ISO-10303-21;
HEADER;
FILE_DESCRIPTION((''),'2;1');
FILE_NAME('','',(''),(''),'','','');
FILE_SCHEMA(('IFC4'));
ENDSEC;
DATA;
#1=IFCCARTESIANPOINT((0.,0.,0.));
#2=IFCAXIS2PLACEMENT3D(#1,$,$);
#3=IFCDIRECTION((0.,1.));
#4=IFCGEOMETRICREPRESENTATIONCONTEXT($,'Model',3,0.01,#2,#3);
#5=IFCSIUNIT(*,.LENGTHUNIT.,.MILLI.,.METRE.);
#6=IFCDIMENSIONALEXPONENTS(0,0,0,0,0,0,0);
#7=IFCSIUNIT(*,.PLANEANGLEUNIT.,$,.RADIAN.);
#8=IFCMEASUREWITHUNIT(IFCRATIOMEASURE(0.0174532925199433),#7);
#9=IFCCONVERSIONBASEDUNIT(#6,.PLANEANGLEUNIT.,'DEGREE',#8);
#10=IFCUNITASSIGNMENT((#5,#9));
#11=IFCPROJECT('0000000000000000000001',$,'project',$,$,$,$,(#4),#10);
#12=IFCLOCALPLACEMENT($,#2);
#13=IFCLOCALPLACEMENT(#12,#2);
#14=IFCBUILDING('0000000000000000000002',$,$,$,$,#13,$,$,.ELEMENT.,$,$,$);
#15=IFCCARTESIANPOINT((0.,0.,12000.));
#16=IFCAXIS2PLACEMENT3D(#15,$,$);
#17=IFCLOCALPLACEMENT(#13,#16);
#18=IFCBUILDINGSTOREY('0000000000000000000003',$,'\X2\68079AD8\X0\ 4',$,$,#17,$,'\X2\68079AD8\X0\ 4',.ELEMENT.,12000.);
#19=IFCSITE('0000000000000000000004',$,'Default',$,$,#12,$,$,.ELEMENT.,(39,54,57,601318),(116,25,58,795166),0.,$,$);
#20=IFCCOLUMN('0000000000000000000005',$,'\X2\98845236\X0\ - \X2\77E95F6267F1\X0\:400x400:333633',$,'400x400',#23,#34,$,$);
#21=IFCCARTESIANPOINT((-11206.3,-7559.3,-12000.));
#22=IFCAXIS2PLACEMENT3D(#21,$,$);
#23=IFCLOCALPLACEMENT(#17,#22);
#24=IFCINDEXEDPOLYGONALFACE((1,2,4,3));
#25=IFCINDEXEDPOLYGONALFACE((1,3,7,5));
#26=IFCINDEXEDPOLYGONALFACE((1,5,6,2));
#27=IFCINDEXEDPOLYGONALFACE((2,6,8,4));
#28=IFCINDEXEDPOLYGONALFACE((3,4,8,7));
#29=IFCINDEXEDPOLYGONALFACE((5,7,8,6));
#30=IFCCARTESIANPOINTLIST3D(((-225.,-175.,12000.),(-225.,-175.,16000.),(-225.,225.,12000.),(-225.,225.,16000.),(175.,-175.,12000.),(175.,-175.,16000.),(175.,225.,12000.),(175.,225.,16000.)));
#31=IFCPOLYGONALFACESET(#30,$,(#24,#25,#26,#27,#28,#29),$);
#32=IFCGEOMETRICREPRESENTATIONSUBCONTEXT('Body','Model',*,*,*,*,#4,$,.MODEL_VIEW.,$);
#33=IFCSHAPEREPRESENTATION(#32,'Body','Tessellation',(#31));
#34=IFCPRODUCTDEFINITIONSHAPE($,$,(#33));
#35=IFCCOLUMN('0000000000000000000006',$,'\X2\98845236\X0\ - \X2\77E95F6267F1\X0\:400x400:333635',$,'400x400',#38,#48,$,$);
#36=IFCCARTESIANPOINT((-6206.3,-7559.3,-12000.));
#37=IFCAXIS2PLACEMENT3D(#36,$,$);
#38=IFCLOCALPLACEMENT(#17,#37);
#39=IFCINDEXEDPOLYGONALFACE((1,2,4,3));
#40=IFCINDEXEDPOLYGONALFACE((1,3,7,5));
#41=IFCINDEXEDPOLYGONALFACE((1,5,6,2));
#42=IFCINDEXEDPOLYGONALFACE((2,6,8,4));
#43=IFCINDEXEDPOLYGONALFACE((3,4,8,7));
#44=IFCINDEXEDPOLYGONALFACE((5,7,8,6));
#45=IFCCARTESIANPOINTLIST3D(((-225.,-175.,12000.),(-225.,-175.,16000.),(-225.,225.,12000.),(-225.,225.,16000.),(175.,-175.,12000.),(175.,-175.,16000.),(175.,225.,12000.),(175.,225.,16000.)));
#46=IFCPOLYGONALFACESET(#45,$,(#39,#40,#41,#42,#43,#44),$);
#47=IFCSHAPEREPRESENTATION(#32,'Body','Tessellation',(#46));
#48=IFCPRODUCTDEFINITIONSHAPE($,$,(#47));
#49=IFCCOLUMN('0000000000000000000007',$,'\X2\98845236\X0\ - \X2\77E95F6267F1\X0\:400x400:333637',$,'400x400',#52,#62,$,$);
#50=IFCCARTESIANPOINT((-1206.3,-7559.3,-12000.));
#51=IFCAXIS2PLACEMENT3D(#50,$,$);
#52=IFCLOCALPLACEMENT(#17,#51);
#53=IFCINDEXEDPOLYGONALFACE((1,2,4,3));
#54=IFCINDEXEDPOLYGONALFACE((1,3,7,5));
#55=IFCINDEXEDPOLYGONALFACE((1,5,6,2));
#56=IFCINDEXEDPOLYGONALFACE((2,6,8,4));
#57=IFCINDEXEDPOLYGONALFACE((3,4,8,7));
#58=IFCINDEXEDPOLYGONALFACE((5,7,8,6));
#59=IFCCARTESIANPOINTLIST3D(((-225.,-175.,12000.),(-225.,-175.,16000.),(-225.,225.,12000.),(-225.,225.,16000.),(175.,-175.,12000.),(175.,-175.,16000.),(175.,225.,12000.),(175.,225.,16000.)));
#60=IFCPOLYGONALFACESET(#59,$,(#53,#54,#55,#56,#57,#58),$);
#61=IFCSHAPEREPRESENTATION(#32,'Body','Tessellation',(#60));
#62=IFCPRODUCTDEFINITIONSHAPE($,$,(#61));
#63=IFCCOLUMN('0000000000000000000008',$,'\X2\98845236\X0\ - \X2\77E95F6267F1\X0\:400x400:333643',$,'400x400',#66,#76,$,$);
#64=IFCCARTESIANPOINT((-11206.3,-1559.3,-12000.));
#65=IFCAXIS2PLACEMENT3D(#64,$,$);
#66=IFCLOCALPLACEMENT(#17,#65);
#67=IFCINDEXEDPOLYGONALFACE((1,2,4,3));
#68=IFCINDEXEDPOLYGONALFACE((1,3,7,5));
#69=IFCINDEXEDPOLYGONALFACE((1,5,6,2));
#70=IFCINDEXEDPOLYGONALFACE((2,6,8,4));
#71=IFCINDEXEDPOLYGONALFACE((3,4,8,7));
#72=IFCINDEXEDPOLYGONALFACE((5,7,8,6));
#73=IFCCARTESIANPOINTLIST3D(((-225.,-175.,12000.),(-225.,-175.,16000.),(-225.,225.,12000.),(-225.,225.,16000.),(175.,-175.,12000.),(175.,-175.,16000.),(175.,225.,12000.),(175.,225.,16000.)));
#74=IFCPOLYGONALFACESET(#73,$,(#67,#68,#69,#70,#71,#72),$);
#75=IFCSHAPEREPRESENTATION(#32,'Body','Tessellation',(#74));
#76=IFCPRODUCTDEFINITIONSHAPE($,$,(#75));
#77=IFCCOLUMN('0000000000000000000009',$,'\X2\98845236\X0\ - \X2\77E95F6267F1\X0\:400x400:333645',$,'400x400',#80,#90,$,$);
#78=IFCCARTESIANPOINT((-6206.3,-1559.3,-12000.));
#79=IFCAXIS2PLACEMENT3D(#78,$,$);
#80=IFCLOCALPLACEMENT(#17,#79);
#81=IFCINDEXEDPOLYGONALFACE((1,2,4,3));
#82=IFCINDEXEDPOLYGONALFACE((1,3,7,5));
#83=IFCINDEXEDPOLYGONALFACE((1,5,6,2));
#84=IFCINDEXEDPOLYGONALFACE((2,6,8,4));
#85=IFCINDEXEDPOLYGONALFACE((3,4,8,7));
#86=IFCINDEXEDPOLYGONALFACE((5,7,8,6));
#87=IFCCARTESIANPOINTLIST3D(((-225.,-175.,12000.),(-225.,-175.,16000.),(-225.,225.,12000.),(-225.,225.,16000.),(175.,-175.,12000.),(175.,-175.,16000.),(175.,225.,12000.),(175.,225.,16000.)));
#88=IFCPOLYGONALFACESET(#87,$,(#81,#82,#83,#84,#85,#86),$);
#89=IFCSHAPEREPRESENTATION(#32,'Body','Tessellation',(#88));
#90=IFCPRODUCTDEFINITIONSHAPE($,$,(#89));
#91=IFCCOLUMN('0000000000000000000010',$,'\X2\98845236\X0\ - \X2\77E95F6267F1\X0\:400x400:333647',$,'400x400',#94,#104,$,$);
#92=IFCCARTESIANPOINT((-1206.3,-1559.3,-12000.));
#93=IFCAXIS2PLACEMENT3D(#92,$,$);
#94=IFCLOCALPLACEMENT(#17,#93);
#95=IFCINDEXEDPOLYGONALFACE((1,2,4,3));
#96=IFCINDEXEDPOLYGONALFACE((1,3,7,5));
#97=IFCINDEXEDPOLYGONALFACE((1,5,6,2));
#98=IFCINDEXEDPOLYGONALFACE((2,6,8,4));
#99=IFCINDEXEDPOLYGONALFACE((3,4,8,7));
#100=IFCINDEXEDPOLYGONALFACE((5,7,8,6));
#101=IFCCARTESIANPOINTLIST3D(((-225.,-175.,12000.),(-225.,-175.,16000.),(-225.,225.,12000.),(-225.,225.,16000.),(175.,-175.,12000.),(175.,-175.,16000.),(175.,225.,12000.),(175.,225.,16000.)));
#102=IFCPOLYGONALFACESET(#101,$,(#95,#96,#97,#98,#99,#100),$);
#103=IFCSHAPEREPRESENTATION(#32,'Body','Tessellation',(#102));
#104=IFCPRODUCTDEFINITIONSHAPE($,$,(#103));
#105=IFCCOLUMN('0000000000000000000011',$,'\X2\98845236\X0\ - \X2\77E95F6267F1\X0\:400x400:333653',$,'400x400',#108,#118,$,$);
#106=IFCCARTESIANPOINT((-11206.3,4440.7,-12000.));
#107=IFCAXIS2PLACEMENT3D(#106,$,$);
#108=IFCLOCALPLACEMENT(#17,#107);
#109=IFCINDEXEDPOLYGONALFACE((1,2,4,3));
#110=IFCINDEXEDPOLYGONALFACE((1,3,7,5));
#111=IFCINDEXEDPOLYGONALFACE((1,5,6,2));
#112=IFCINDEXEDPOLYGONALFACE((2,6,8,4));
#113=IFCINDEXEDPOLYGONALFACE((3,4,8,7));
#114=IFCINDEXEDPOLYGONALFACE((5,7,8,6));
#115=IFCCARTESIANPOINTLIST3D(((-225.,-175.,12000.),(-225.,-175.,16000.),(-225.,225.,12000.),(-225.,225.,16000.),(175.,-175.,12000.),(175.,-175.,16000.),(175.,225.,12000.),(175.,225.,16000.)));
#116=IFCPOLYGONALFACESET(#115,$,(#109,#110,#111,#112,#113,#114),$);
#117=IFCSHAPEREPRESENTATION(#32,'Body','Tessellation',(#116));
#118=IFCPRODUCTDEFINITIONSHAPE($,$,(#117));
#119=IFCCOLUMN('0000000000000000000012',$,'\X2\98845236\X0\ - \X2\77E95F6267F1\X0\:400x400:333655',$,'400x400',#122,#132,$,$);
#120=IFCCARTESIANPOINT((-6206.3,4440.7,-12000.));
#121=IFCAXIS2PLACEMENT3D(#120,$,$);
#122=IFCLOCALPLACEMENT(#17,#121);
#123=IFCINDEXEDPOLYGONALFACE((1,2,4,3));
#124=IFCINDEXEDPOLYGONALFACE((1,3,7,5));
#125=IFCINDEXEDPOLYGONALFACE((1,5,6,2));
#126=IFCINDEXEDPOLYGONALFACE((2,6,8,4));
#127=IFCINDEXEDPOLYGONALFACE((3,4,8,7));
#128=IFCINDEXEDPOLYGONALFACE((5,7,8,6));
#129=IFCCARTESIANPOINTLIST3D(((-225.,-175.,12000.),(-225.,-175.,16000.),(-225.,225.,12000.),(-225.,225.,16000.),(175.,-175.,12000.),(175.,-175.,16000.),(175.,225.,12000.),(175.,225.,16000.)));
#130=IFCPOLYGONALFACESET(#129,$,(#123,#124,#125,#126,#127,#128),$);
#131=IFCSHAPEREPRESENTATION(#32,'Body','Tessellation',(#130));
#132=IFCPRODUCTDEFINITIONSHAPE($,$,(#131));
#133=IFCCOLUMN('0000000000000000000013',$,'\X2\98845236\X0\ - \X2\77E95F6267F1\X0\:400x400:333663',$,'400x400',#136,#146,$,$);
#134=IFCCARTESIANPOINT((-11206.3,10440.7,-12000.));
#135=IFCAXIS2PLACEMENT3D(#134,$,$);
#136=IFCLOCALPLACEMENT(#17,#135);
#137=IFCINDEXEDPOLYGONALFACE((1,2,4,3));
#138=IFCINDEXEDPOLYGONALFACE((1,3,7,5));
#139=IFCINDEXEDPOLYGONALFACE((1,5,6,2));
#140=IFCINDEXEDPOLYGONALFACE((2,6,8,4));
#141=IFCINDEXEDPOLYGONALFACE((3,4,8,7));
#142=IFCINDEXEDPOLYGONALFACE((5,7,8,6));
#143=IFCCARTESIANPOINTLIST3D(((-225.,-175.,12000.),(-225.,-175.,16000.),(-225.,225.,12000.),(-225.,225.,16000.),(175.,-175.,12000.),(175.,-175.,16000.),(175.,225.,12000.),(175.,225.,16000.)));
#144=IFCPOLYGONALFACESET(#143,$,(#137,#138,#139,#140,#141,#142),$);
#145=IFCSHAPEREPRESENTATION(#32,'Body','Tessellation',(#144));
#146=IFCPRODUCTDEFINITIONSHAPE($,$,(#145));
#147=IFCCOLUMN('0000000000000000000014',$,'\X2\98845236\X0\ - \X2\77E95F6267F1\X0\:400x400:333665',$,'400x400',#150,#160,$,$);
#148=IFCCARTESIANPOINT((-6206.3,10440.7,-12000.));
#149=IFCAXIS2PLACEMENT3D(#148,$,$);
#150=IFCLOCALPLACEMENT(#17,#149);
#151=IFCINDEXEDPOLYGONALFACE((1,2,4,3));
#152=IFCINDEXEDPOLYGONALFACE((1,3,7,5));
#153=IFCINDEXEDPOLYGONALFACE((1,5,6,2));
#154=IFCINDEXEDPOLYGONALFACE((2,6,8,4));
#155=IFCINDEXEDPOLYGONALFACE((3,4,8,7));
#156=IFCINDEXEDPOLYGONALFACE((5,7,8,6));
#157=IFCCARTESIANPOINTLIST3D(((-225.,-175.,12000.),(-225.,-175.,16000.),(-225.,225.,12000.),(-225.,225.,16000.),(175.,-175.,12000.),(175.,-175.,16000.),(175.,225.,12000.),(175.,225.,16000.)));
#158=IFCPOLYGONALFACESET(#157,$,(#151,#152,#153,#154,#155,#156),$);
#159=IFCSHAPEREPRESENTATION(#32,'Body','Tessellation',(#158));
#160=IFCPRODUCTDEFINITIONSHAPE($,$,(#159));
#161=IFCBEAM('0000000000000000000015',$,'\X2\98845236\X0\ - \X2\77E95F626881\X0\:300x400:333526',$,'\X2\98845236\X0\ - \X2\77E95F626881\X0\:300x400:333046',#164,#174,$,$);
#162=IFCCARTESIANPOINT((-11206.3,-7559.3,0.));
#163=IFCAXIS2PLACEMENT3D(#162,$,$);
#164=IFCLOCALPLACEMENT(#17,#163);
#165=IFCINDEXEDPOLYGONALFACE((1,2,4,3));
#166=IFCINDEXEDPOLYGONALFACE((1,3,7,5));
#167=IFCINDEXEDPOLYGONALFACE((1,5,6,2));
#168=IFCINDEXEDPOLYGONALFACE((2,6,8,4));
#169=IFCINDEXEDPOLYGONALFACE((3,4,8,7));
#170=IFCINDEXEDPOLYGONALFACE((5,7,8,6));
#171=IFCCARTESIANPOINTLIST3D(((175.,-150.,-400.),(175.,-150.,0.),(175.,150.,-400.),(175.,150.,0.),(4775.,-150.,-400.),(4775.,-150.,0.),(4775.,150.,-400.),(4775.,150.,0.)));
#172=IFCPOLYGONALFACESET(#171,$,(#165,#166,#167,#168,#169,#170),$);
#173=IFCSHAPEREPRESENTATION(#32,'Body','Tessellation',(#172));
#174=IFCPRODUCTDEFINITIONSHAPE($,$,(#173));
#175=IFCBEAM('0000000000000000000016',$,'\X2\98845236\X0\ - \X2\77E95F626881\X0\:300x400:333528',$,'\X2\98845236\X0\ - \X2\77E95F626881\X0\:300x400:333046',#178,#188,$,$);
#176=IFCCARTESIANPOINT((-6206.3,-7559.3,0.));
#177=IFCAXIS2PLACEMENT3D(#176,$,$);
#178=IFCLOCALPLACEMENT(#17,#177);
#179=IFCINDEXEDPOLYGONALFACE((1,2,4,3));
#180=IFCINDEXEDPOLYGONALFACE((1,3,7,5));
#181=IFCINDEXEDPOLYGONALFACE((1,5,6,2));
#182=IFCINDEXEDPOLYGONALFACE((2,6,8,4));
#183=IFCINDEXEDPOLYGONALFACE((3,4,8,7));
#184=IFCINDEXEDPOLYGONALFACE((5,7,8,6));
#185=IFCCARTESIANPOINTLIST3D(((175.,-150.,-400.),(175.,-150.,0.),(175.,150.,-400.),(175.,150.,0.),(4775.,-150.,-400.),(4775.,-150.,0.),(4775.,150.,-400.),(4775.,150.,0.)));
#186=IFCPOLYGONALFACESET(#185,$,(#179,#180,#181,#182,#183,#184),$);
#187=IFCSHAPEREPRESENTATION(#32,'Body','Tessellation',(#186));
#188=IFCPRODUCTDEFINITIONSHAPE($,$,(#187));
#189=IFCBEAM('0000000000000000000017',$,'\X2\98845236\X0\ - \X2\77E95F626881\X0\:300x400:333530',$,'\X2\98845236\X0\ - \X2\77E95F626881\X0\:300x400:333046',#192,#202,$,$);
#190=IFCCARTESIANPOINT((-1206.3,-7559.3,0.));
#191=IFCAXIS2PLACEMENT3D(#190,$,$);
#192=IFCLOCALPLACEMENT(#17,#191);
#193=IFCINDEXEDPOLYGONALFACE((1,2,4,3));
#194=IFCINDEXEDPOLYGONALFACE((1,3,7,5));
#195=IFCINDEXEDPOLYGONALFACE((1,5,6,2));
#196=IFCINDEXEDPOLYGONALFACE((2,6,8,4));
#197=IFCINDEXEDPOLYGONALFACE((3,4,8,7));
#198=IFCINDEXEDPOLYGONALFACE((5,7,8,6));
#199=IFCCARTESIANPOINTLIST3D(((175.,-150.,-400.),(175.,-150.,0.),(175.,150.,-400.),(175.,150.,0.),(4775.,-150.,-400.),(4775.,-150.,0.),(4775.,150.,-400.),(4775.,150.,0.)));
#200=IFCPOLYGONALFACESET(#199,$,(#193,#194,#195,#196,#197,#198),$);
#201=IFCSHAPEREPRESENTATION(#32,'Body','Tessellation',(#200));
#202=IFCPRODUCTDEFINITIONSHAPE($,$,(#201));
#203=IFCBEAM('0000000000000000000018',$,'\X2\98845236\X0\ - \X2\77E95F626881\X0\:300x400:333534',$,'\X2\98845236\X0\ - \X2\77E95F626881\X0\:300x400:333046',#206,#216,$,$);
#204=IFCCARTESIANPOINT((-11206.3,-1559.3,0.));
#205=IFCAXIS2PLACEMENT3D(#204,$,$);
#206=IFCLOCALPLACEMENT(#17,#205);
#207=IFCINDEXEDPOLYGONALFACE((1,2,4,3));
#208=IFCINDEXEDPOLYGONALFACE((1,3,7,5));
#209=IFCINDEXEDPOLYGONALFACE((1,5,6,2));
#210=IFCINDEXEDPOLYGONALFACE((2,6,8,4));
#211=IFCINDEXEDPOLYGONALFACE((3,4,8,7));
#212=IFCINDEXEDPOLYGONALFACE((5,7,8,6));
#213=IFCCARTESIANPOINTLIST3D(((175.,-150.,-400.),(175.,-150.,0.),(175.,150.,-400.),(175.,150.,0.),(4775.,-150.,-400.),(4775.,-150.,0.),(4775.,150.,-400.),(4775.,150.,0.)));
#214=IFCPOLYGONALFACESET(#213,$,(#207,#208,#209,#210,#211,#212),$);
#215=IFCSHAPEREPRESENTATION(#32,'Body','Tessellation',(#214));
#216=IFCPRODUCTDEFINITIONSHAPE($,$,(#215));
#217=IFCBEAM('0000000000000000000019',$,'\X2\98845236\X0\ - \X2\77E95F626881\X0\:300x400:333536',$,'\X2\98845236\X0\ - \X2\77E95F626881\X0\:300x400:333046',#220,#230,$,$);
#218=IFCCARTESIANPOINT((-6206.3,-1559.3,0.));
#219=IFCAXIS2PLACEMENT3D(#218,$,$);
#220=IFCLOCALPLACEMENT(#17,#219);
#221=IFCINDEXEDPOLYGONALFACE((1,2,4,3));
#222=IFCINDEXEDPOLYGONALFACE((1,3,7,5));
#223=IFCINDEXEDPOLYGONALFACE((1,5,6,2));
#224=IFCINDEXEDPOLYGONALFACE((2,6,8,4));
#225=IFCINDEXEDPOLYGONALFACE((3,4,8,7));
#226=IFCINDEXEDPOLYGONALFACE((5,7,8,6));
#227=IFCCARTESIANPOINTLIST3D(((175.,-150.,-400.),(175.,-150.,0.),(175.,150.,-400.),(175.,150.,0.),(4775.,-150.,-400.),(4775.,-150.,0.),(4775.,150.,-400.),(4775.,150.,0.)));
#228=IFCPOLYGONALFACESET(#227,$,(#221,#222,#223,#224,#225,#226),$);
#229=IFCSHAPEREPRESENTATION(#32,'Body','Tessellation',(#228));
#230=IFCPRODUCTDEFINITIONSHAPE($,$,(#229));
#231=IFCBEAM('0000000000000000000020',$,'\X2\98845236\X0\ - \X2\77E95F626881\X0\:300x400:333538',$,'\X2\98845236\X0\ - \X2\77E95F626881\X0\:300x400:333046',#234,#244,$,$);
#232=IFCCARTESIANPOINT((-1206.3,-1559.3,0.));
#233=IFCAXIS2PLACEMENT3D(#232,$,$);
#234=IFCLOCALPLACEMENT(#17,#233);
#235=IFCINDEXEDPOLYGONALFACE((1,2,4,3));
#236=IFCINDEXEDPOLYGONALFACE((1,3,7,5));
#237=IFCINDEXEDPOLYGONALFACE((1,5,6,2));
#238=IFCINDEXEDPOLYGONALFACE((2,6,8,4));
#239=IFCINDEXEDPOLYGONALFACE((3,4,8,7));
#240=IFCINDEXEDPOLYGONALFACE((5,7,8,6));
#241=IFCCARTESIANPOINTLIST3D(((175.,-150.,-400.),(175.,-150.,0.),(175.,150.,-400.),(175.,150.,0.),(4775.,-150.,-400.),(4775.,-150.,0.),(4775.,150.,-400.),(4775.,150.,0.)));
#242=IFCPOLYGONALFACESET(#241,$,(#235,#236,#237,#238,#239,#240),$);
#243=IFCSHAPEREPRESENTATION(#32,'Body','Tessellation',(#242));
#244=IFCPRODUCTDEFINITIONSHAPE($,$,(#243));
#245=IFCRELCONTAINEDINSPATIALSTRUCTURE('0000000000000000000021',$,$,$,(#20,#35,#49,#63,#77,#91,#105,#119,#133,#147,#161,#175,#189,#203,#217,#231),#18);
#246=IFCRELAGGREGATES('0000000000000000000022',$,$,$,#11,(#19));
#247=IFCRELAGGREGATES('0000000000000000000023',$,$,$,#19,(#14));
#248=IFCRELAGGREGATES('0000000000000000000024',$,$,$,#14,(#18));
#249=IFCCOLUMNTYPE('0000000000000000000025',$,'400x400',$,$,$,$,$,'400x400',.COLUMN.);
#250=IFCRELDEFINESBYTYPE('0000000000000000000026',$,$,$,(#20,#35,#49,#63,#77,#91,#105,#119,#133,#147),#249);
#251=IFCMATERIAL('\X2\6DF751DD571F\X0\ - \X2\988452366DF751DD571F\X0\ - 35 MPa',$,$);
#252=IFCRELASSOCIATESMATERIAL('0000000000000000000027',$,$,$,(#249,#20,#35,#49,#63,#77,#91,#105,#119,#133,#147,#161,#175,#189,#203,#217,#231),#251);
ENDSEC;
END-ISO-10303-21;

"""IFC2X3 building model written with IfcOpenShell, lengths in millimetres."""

from ifc_helpers import new_model, entity, si_unit, converted_unit, direction, frame, frame_2d, origin, place, context, subcontext, project, spatial, rectangle, extrude, source, transform, mapped, material, type_object, type_shapes, element, save


model = new_model("IFC2X3")

# Units and contexts
model_context = context("Model", 3, precision=0.01, world=origin(), true_north=direction((0.0, 1.0)))
body_context = subcontext(model_context, "Body", "Model", "MODEL_VIEW")
ifc_project = project(units=[si_unit("LENGTHUNIT", "METRE", prefix="MILLI"), converted_unit("PLANEANGLEUNIT", "DEGREE", entity("IfcRatioMeasure", 0.0174532925199433), si_unit("PLANEANGLEUNIT", "RADIAN"), dimensions=[0, 0, 0, 0, 0, 0, 0])], contexts=[model_context])

# Site, building, storey
site_placement = place(None, origin())
site = spatial("IfcSite", under=ifc_project, at=site_placement, Name="Default", CompositionType="ELEMENT", RefLatitude=(39, 54, 57, 601318), RefLongitude=(116, 25, 58, 795166), RefElevation=0.0)
building_placement = place(site_placement, origin())
building = spatial("IfcBuilding", under=site, at=building_placement, CompositionType="ELEMENT")
storey_placement = place(building_placement, frame((0.0, 0.0, 12000.0)))
storey = spatial("IfcBuildingStorey", under=building, at=storey_placement, Name="标高 4", LongName="标高 4", CompositionType="ELEMENT", Elevation=12000.0)

# Columns
ifc_material = material(Name="混凝土 - 预制混凝土 - 35 MPa")
column_type = type_object("IfcColumnType", Name="400x400", ElementType="400x400", PredefinedType="COLUMN", material=ifc_material)
shared_shape = source(origin(), body_context, "Body", "SweptSolid", [
    extrude(rectangle(XDim=400.0, YDim=400.0, at=frame_2d((0.0, 0.0), x_axis=(1.0, 0.0))), frame((-25.0, 25.0, 12000.0)), (0.0, 0.0, 1.0), 4000.0),
])
type_shapes(column_type, [shared_shape])
for number, where, name in (
    (1, (-11206.3, -7559.3, -12000.0), "预制 - 矩形柱:400x400:333633"),
    (2, (-6206.3, -7559.3, -12000.0), "预制 - 矩形柱:400x400:333635"),
    (3, (-1206.3, -7559.3, -12000.0), "预制 - 矩形柱:400x400:333637"),
    (4, (-11206.3, -1559.3, -12000.0), "预制 - 矩形柱:400x400:333643"),
    (5, (-6206.3, -1559.3, -12000.0), "预制 - 矩形柱:400x400:333645"),
    (6, (-1206.3, -1559.3, -12000.0), "预制 - 矩形柱:400x400:333647"),
    (7, (-11206.3, 4440.7, -12000.0), "预制 - 矩形柱:400x400:333653"),
    (8, (-6206.3, 4440.7, -12000.0), "预制 - 矩形柱:400x400:333655"),
    (9, (-11206.3, 10440.7, -12000.0), "预制 - 矩形柱:400x400:333663"),
    (10, (-6206.3, 10440.7, -12000.0), "预制 - 矩形柱:400x400:333665"),
):
    element("IfcColumn", number, at=place(storey_placement, frame(where)), inside=storey, type_object=column_type, material=ifc_material, Name=name, ObjectType="400x400", context=body_context, shape_type="MappedRepresentation", body=[
        mapped(shared_shape, transform((0.0, 0.0, 0.0), scale=1.0)),
    ])

# Beams
for number, where, name in (
    (11, (-11206.3, -7559.3, 0.0), "预制 - 矩形梁:300x400:333526"),
    (12, (-6206.3, -7559.3, 0.0), "预制 - 矩形梁:300x400:333528"),
):
    element("IfcBeam", number, at=place(storey_placement, frame(where)), inside=storey, material=ifc_material, Name=name, ObjectType="预制 - 矩形梁:300x400:333046", context=body_context, shape_type="SweptSolid", body=[
        extrude(rectangle(XDim=400.0, YDim=300.0, at=frame_2d((0.0, 0.0), x_axis=(1.0, 0.0))), frame((175.0, 0.0, -200.0), z_axis=(1.0, 0.0, 0.0), x_axis=(0.0, 0.0, -1.0)), (0.0, 0.0, 1.0), 4600.0),
    ])
beam_1_placement = place(storey_placement, frame((-1206.3, -7559.3, 0.0)))
element("IfcBeam", 13, at=beam_1_placement, inside=storey, material=ifc_material, Name="预制 - 矩形梁:300x400:333530", ObjectType="预制 - 矩形梁:300x400:333046", context=body_context, shape_type="SweptSolid", body=[
    extrude(rectangle(XDim=400.0, YDim=300.0, at=frame_2d((0.0, 0.0), x_axis=(1.0, 0.0))), frame((175.0, 0.0, -200.0), z_axis=(1.0, 0.0, 0.0), x_axis=(0.0, 0.0, -1.0)), (0.0, 0.0, 1.0), 4600.0),
])
for number, where, name in (
    (14, (-11206.3, -1559.3, 0.0), "预制 - 矩形梁:300x400:333534"),
    (15, (-6206.3, -1559.3, 0.0), "预制 - 矩形梁:300x400:333536"),
    (16, (-1206.3, -1559.3, 0.0), "预制 - 矩形梁:300x400:333538"),
):
    element("IfcBeam", number, at=place(storey_placement, frame(where)), inside=storey, material=ifc_material, Name=name, ObjectType="预制 - 矩形梁:300x400:333046", context=body_context, shape_type="SweptSolid", body=[
        extrude(rectangle(XDim=400.0, YDim=300.0, at=frame_2d((0.0, 0.0), x_axis=(1.0, 0.0))), frame((175.0, 0.0, -200.0), z_axis=(1.0, 0.0, 0.0), x_axis=(0.0, 0.0, -1.0)), (0.0, 0.0, 1.0), 4600.0),
    ])

save(model, "model.ifc")
